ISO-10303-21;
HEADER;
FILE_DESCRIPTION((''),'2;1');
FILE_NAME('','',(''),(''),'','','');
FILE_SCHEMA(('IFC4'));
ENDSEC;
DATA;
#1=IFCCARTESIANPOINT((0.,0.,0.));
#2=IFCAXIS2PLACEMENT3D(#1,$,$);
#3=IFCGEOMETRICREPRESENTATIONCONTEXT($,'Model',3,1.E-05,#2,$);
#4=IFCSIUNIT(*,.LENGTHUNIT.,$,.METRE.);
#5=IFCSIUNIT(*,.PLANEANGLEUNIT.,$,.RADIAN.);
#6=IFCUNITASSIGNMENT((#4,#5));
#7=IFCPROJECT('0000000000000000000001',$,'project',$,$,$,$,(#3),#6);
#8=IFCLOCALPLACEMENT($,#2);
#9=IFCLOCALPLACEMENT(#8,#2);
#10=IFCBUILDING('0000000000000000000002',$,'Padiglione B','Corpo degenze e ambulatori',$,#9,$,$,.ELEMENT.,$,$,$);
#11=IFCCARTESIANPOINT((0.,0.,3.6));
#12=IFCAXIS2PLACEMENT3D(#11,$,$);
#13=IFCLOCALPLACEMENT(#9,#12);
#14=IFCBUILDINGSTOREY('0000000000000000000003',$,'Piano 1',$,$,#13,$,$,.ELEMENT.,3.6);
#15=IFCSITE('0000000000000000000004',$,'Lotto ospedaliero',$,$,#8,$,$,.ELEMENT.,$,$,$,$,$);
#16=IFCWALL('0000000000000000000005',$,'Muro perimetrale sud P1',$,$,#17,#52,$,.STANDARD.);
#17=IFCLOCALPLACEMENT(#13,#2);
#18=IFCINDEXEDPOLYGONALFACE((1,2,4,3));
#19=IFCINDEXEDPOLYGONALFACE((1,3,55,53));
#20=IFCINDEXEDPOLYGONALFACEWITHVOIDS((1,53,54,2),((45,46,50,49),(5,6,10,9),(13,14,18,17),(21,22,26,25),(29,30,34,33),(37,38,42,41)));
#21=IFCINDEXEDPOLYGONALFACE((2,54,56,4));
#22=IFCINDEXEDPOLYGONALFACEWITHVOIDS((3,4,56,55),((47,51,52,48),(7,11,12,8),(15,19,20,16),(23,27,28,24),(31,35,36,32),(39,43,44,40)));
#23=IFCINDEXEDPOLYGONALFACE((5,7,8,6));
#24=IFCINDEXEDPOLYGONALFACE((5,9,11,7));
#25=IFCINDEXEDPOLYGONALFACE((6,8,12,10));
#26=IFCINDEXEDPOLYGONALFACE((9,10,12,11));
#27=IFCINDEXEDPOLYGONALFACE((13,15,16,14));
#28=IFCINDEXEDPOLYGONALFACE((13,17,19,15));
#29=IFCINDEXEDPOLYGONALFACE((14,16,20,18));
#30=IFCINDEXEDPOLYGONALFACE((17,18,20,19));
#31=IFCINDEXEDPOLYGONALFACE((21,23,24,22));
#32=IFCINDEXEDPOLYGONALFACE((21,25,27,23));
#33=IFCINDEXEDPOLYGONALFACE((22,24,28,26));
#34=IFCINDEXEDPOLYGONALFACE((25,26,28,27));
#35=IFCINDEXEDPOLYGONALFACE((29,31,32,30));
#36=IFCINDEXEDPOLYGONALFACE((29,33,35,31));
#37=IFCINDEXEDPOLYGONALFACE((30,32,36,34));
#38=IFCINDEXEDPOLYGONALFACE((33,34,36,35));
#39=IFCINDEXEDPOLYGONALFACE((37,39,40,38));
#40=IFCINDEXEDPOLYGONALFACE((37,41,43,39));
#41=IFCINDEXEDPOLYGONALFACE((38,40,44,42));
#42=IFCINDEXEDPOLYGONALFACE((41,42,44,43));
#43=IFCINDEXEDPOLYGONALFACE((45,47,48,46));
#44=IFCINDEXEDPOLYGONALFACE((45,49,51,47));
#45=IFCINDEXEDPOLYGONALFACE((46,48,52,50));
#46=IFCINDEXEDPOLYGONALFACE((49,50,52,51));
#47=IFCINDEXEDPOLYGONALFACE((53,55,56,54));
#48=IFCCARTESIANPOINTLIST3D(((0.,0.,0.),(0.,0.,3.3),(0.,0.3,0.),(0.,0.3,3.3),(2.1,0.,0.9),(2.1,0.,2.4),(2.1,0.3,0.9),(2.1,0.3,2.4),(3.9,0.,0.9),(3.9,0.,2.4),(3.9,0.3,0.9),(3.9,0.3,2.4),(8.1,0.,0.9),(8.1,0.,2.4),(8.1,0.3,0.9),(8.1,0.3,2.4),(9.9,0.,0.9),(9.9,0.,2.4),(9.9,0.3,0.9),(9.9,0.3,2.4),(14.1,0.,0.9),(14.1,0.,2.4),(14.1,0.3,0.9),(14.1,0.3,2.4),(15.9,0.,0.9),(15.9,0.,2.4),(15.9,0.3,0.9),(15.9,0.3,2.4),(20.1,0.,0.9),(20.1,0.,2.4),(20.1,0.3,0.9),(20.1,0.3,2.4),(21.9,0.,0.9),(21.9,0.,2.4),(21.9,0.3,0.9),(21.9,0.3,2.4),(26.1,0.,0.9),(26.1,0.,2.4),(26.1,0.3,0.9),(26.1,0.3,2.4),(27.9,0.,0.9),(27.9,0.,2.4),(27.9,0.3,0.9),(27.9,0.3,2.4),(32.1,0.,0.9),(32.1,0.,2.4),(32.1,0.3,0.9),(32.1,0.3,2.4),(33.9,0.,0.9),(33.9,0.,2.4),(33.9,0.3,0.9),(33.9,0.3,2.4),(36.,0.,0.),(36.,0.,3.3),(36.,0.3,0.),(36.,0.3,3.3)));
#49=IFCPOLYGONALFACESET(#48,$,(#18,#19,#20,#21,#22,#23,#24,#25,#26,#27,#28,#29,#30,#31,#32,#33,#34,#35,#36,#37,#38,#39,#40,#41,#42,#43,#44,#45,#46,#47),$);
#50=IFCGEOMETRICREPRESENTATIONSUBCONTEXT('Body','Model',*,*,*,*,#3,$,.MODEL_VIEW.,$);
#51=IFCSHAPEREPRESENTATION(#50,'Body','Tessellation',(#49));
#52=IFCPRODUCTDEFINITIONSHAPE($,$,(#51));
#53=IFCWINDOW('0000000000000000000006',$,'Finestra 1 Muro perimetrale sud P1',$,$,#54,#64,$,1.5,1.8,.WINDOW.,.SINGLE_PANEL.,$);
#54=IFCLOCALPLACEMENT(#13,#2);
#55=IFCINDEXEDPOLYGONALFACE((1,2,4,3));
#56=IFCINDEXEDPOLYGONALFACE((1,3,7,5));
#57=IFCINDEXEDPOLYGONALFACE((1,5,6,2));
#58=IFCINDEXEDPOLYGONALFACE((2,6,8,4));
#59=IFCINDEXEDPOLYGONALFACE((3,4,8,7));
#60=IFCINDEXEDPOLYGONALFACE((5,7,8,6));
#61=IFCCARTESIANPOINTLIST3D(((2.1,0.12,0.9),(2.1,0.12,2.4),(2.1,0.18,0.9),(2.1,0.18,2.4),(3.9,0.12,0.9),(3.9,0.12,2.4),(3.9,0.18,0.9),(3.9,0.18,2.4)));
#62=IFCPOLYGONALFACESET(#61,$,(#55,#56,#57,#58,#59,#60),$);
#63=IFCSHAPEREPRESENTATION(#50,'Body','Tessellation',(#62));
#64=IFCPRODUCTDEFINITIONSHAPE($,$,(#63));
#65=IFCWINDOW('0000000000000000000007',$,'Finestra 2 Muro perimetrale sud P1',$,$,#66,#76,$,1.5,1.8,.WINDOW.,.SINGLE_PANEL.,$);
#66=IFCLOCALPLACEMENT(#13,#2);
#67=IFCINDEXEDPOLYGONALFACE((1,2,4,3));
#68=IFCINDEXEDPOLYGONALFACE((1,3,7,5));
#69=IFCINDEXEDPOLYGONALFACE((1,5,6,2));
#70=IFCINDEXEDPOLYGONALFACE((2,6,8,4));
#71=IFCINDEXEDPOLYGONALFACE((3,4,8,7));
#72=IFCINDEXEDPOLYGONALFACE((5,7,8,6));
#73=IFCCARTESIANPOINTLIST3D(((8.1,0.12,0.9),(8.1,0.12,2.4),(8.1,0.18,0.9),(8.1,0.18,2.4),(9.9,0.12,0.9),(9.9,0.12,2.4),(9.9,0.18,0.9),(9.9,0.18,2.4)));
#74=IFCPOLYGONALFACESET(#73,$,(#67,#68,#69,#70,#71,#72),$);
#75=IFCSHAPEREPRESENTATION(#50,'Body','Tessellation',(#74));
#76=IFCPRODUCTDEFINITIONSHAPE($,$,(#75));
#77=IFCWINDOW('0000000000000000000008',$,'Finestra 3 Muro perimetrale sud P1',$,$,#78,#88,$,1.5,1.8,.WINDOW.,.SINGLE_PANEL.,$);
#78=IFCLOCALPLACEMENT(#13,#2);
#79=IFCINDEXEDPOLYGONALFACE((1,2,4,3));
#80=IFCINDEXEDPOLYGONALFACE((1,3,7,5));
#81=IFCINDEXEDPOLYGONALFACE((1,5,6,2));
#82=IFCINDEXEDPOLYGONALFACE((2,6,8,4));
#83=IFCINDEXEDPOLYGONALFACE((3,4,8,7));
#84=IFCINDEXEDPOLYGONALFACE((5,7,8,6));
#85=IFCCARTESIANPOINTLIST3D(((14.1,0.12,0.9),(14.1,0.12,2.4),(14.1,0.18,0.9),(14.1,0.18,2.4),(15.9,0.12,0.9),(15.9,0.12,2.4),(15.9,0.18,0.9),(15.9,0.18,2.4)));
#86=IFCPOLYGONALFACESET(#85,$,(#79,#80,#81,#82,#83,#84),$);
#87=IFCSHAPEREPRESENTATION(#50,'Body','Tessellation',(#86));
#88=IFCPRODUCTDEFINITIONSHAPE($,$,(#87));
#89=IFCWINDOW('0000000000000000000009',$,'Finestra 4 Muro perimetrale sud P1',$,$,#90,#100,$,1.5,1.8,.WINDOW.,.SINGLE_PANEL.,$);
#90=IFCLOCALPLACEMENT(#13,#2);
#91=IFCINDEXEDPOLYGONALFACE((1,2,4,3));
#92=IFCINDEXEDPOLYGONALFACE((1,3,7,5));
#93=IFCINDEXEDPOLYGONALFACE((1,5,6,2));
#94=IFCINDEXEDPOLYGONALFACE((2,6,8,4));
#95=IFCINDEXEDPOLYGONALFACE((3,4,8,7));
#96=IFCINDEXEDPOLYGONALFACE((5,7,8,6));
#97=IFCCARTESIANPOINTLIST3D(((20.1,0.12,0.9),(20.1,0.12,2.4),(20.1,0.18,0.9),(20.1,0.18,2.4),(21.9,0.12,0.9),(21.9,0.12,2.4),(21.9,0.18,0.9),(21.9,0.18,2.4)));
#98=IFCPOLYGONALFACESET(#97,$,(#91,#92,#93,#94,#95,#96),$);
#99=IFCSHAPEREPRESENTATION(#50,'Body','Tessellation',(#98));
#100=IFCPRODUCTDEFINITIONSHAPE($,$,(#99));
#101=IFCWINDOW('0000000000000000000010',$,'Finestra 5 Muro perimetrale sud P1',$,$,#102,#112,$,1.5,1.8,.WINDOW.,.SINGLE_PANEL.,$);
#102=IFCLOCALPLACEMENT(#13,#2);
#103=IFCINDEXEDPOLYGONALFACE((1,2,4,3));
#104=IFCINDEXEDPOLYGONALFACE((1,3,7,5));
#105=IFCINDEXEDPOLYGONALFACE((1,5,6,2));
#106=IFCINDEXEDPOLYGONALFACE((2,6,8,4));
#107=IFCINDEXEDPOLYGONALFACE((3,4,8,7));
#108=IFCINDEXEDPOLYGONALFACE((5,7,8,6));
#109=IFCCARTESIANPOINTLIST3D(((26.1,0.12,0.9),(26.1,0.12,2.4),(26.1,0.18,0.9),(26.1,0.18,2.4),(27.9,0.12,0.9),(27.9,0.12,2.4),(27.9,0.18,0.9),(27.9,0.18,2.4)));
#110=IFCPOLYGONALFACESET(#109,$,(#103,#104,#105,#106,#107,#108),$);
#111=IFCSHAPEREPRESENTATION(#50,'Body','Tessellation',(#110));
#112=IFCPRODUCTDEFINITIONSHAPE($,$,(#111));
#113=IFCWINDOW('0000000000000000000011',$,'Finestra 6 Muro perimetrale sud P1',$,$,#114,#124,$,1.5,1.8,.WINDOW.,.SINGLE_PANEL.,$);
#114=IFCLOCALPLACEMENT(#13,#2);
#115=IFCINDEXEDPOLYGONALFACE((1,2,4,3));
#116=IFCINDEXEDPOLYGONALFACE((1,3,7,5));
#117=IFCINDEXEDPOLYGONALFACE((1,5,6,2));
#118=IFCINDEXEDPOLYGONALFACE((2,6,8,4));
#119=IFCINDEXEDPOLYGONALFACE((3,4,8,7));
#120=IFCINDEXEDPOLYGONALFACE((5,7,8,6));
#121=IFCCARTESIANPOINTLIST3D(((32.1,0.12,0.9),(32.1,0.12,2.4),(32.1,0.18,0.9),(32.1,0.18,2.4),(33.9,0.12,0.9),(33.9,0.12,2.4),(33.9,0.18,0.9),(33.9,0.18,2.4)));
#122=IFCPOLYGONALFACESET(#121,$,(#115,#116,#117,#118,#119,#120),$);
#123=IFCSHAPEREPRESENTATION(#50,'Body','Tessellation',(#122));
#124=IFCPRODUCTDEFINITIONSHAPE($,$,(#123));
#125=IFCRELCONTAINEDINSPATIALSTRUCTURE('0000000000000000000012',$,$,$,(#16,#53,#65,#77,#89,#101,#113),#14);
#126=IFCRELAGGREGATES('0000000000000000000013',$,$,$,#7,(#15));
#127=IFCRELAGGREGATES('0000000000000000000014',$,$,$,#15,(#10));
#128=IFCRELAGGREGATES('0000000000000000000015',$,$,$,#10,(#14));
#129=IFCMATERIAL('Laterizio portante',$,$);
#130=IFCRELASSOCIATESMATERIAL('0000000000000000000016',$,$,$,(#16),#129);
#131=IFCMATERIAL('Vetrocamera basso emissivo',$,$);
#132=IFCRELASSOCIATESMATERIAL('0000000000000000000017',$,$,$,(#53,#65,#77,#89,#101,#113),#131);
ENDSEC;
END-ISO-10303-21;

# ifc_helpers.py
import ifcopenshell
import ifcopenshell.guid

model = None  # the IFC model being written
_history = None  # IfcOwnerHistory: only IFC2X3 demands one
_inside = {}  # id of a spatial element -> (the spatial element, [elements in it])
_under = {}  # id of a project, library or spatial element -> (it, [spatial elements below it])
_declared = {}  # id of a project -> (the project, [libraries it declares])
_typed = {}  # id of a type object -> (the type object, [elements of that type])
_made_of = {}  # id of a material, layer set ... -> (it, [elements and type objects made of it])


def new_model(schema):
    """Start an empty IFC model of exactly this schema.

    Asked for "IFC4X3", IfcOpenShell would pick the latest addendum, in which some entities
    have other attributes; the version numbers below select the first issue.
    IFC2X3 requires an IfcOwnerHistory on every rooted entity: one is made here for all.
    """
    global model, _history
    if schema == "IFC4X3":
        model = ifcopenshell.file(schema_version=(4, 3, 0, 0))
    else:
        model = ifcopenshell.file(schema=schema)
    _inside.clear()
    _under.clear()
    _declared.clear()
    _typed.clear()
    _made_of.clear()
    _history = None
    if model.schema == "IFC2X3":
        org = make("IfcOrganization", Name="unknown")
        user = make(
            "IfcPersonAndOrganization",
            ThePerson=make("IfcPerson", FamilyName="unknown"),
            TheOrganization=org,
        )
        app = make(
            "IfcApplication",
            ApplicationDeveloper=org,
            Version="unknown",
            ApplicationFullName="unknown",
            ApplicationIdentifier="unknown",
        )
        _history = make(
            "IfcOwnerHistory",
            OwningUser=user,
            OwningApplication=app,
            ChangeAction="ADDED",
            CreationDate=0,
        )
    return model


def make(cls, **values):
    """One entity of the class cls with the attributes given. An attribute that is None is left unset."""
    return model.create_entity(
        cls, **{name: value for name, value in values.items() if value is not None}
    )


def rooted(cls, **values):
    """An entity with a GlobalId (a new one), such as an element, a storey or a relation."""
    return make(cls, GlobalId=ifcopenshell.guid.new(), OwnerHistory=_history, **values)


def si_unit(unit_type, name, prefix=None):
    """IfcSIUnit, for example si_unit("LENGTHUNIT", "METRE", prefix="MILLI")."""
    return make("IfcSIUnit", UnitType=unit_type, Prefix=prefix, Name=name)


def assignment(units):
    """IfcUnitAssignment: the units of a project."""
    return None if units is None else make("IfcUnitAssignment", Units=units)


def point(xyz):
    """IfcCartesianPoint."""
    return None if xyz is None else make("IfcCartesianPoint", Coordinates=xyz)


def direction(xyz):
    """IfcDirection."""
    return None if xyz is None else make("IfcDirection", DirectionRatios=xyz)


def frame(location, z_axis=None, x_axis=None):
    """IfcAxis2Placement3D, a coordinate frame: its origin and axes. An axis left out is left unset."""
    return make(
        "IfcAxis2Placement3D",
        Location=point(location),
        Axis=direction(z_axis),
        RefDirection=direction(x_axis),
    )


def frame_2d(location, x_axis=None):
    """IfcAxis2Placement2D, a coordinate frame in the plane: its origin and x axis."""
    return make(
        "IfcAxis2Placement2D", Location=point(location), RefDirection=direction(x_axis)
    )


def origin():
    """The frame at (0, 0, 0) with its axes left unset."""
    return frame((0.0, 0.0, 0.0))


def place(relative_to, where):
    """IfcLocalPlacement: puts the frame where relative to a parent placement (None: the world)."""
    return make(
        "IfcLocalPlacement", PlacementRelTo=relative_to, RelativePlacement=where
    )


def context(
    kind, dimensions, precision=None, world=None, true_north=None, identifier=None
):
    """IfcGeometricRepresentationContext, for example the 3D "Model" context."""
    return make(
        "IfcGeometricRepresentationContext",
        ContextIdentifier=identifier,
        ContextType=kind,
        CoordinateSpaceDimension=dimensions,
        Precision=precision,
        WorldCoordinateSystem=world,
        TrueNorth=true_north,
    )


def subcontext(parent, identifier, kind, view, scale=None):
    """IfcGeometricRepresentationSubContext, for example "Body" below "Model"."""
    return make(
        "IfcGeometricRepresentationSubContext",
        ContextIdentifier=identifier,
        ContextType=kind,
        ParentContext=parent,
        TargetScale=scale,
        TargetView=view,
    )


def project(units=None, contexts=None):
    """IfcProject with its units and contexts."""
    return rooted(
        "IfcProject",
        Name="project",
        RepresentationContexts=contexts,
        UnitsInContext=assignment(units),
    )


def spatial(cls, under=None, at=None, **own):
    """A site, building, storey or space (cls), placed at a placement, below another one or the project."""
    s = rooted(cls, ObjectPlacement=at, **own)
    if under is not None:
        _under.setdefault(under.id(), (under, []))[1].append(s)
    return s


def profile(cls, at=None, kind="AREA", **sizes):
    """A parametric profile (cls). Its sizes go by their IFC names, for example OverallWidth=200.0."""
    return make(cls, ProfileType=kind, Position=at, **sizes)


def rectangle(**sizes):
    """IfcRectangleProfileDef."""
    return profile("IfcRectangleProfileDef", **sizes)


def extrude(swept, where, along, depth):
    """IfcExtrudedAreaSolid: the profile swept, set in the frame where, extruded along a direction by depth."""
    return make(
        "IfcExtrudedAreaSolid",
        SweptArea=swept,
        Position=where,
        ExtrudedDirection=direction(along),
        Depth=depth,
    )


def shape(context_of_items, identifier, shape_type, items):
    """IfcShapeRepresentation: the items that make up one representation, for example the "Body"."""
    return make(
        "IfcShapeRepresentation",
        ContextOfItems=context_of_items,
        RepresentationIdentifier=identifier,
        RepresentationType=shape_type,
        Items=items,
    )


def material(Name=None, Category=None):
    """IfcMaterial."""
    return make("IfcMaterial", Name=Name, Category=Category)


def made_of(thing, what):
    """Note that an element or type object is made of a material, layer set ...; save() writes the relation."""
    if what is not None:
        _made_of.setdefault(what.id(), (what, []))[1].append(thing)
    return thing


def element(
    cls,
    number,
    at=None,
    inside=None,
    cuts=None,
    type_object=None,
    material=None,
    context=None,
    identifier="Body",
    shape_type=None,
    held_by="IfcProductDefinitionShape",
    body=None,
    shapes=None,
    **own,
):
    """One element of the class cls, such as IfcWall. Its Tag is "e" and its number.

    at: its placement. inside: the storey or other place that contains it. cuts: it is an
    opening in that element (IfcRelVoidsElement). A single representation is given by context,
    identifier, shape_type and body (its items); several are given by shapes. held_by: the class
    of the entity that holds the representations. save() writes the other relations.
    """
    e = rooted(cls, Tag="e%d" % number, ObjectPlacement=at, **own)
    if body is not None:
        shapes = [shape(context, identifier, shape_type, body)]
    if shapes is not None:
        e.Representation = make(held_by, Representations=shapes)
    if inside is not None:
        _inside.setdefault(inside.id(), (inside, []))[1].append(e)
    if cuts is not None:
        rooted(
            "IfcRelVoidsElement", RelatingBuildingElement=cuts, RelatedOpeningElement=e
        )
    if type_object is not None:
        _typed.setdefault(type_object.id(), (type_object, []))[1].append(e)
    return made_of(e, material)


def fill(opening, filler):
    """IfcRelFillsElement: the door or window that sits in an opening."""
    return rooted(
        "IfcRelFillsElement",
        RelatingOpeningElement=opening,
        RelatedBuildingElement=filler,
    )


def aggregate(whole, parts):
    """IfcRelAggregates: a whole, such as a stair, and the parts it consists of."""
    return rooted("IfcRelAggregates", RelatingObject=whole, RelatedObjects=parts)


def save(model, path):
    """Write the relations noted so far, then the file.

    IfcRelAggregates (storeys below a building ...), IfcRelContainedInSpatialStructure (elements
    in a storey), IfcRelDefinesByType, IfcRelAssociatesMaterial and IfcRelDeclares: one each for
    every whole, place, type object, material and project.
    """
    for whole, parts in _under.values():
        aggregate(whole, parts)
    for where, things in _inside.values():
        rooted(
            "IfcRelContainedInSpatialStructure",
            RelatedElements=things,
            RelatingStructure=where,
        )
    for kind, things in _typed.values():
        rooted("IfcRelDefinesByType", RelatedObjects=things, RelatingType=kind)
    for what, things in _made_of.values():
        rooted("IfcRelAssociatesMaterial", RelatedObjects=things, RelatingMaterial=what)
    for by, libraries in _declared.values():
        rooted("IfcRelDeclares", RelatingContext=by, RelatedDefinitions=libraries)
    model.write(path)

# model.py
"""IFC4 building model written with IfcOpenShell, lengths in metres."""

from ifc_helpers import new_model, si_unit, frame, frame_2d, origin, place, context, subcontext, project, spatial, rectangle, extrude, material, element, fill, save


model = new_model("IFC4")

# Units and contexts
model_context = context("Model", 3, precision=1e-05, world=origin())
body_context = subcontext(model_context, "Body", "Model", "MODEL_VIEW")
ifc_project = project(units=[si_unit("LENGTHUNIT", "METRE"), si_unit("PLANEANGLEUNIT", "RADIAN")], contexts=[model_context])

# Site, building, storey
site_placement = place(None, origin())
site = spatial("IfcSite", under=ifc_project, at=site_placement, Name="Lotto ospedaliero", CompositionType="ELEMENT")
building_placement = place(site_placement, origin())
building = spatial("IfcBuilding", under=site, at=building_placement, Name="Padiglione B", Description="Corpo degenze e ambulatori", CompositionType="ELEMENT")
storey_placement = place(building_placement, frame((0.0, 0.0, 3.6)))
storey = spatial("IfcBuildingStorey", under=building, at=storey_placement, Name="Piano 1", CompositionType="ELEMENT", Elevation=3.6)

# Wall, openings, windows
ifc_material_1 = material(Name="Laterizio portante")
wall_1_placement = place(storey_placement, origin())
wall_1 = element("IfcWall", 1, at=wall_1_placement, inside=storey, material=ifc_material_1, Name="Muro perimetrale sud P1", PredefinedType="STANDARD", context=body_context, shape_type="SweptSolid", body=[
    extrude(rectangle(XDim=36.0, YDim=0.3, at=frame_2d((18.0, 0.15))), origin(), (0.0, 0.0, 1.0), 3.3),
])
opening_1_placement = place(wall_1_placement, frame((2.1, -0.1, 0.9)))
opening_1 = element("IfcOpeningElement", 2, at=opening_1_placement, cuts=wall_1, PredefinedType="OPENING", context=body_context, shape_type="SweptSolid", body=[
    extrude(rectangle(XDim=1.8, YDim=0.5, at=frame_2d((0.9, 0.25))), origin(), (0.0, 0.0, 1.0), 1.5),
])
opening_2_placement = place(wall_1_placement, frame((8.1, -0.1, 0.9)))
opening_2 = element("IfcOpeningElement", 3, at=opening_2_placement, cuts=wall_1, PredefinedType="OPENING", context=body_context, shape_type="SweptSolid", body=[
    extrude(rectangle(XDim=1.8, YDim=0.5, at=frame_2d((0.9, 0.25))), origin(), (0.0, 0.0, 1.0), 1.5),
])
opening_3_placement = place(wall_1_placement, frame((14.1, -0.1, 0.9)))
opening_3 = element("IfcOpeningElement", 4, at=opening_3_placement, cuts=wall_1, PredefinedType="OPENING", context=body_context, shape_type="SweptSolid", body=[
    extrude(rectangle(XDim=1.8, YDim=0.5, at=frame_2d((0.9, 0.25))), origin(), (0.0, 0.0, 1.0), 1.5),
])
opening_4_placement = place(wall_1_placement, frame((20.1, -0.1, 0.9)))
opening_4 = element("IfcOpeningElement", 5, at=opening_4_placement, cuts=wall_1, PredefinedType="OPENING", context=body_context, shape_type="SweptSolid", body=[
    extrude(rectangle(XDim=1.8, YDim=0.5, at=frame_2d((0.9, 0.25))), origin(), (0.0, 0.0, 1.0), 1.5),
])
opening_5_placement = place(wall_1_placement, frame((26.1, -0.1, 0.9)))
opening_5 = element("IfcOpeningElement", 6, at=opening_5_placement, cuts=wall_1, PredefinedType="OPENING", context=body_context, shape_type="SweptSolid", body=[
    extrude(rectangle(XDim=1.8, YDim=0.5, at=frame_2d((0.9, 0.25))), origin(), (0.0, 0.0, 1.0), 1.5),
])
opening_6_placement = place(wall_1_placement, frame((32.1, -0.1, 0.9)))
opening_6 = element("IfcOpeningElement", 7, at=opening_6_placement, cuts=wall_1, PredefinedType="OPENING", context=body_context, shape_type="SweptSolid", body=[
    extrude(rectangle(XDim=1.8, YDim=0.5, at=frame_2d((0.9, 0.25))), origin(), (0.0, 0.0, 1.0), 1.5),
])
ifc_material_2 = material(Name="Vetrocamera basso emissivo")
window_1_placement = place(wall_1_placement, frame((2.1, 0.12, 0.9)))
window_1 = element("IfcWindow", 8, at=window_1_placement, inside=storey, material=ifc_material_2, Name="Finestra 1 Muro perimetrale sud P1", OverallHeight=1.5, OverallWidth=1.8, PartitioningType="SINGLE_PANEL", PredefinedType="WINDOW", context=body_context, shape_type="SweptSolid", body=[
    extrude(rectangle(XDim=1.8, YDim=0.06, at=frame_2d((0.9, 0.03))), origin(), (0.0, 0.0, 1.0), 1.5),
])
fill(opening_1, window_1)
window_2_placement = place(wall_1_placement, frame((8.1, 0.12, 0.9)))
window_2 = element("IfcWindow", 9, at=window_2_placement, inside=storey, material=ifc_material_2, Name="Finestra 2 Muro perimetrale sud P1", OverallHeight=1.5, OverallWidth=1.8, PartitioningType="SINGLE_PANEL", PredefinedType="WINDOW", context=body_context, shape_type="SweptSolid", body=[
    extrude(rectangle(XDim=1.8, YDim=0.06, at=frame_2d((0.9, 0.03))), origin(), (0.0, 0.0, 1.0), 1.5),
])
fill(opening_2, window_2)
window_3_placement = place(wall_1_placement, frame((14.1, 0.12, 0.9)))
window_3 = element("IfcWindow", 10, at=window_3_placement, inside=storey, material=ifc_material_2, Name="Finestra 3 Muro perimetrale sud P1", OverallHeight=1.5, OverallWidth=1.8, PartitioningType="SINGLE_PANEL", PredefinedType="WINDOW", context=body_context, shape_type="SweptSolid", body=[
    extrude(rectangle(XDim=1.8, YDim=0.06, at=frame_2d((0.9, 0.03))), origin(), (0.0, 0.0, 1.0), 1.5),
])
fill(opening_3, window_3)
window_4_placement = place(wall_1_placement, frame((20.1, 0.12, 0.9)))
window_4 = element("IfcWindow", 11, at=window_4_placement, inside=storey, material=ifc_material_2, Name="Finestra 4 Muro perimetrale sud P1", OverallHeight=1.5, OverallWidth=1.8, PartitioningType="SINGLE_PANEL", PredefinedType="WINDOW", context=body_context, shape_type="SweptSolid", body=[
    extrude(rectangle(XDim=1.8, YDim=0.06, at=frame_2d((0.9, 0.03))), origin(), (0.0, 0.0, 1.0), 1.5),
])
fill(opening_4, window_4)
window_5_placement = place(wall_1_placement, frame((26.1, 0.12, 0.9)))
window_5 = element("IfcWindow", 12, at=window_5_placement, inside=storey, material=ifc_material_2, Name="Finestra 5 Muro perimetrale sud P1", OverallHeight=1.5, OverallWidth=1.8, PartitioningType="SINGLE_PANEL", PredefinedType="WINDOW", context=body_context, shape_type="SweptSolid", body=[
    extrude(rectangle(XDim=1.8, YDim=0.06, at=frame_2d((0.9, 0.03))), origin(), (0.0, 0.0, 1.0), 1.5),
])
fill(opening_5, window_5)
window_6_placement = place(wall_1_placement, frame((32.1, 0.12, 0.9)))
window_6 = element("IfcWindow", 13, at=window_6_placement, inside=storey, material=ifc_material_2, Name="Finestra 6 Muro perimetrale sud P1", OverallHeight=1.5, OverallWidth=1.8, PartitioningType="SINGLE_PANEL", PredefinedType="WINDOW", context=body_context, shape_type="SweptSolid", body=[
    extrude(rectangle(XDim=1.8, YDim=0.06, at=frame_2d((0.9, 0.03))), origin(), (0.0, 0.0, 1.0), 1.5),
])
fill(opening_6, window_6)

save(model, "model.ifc")
